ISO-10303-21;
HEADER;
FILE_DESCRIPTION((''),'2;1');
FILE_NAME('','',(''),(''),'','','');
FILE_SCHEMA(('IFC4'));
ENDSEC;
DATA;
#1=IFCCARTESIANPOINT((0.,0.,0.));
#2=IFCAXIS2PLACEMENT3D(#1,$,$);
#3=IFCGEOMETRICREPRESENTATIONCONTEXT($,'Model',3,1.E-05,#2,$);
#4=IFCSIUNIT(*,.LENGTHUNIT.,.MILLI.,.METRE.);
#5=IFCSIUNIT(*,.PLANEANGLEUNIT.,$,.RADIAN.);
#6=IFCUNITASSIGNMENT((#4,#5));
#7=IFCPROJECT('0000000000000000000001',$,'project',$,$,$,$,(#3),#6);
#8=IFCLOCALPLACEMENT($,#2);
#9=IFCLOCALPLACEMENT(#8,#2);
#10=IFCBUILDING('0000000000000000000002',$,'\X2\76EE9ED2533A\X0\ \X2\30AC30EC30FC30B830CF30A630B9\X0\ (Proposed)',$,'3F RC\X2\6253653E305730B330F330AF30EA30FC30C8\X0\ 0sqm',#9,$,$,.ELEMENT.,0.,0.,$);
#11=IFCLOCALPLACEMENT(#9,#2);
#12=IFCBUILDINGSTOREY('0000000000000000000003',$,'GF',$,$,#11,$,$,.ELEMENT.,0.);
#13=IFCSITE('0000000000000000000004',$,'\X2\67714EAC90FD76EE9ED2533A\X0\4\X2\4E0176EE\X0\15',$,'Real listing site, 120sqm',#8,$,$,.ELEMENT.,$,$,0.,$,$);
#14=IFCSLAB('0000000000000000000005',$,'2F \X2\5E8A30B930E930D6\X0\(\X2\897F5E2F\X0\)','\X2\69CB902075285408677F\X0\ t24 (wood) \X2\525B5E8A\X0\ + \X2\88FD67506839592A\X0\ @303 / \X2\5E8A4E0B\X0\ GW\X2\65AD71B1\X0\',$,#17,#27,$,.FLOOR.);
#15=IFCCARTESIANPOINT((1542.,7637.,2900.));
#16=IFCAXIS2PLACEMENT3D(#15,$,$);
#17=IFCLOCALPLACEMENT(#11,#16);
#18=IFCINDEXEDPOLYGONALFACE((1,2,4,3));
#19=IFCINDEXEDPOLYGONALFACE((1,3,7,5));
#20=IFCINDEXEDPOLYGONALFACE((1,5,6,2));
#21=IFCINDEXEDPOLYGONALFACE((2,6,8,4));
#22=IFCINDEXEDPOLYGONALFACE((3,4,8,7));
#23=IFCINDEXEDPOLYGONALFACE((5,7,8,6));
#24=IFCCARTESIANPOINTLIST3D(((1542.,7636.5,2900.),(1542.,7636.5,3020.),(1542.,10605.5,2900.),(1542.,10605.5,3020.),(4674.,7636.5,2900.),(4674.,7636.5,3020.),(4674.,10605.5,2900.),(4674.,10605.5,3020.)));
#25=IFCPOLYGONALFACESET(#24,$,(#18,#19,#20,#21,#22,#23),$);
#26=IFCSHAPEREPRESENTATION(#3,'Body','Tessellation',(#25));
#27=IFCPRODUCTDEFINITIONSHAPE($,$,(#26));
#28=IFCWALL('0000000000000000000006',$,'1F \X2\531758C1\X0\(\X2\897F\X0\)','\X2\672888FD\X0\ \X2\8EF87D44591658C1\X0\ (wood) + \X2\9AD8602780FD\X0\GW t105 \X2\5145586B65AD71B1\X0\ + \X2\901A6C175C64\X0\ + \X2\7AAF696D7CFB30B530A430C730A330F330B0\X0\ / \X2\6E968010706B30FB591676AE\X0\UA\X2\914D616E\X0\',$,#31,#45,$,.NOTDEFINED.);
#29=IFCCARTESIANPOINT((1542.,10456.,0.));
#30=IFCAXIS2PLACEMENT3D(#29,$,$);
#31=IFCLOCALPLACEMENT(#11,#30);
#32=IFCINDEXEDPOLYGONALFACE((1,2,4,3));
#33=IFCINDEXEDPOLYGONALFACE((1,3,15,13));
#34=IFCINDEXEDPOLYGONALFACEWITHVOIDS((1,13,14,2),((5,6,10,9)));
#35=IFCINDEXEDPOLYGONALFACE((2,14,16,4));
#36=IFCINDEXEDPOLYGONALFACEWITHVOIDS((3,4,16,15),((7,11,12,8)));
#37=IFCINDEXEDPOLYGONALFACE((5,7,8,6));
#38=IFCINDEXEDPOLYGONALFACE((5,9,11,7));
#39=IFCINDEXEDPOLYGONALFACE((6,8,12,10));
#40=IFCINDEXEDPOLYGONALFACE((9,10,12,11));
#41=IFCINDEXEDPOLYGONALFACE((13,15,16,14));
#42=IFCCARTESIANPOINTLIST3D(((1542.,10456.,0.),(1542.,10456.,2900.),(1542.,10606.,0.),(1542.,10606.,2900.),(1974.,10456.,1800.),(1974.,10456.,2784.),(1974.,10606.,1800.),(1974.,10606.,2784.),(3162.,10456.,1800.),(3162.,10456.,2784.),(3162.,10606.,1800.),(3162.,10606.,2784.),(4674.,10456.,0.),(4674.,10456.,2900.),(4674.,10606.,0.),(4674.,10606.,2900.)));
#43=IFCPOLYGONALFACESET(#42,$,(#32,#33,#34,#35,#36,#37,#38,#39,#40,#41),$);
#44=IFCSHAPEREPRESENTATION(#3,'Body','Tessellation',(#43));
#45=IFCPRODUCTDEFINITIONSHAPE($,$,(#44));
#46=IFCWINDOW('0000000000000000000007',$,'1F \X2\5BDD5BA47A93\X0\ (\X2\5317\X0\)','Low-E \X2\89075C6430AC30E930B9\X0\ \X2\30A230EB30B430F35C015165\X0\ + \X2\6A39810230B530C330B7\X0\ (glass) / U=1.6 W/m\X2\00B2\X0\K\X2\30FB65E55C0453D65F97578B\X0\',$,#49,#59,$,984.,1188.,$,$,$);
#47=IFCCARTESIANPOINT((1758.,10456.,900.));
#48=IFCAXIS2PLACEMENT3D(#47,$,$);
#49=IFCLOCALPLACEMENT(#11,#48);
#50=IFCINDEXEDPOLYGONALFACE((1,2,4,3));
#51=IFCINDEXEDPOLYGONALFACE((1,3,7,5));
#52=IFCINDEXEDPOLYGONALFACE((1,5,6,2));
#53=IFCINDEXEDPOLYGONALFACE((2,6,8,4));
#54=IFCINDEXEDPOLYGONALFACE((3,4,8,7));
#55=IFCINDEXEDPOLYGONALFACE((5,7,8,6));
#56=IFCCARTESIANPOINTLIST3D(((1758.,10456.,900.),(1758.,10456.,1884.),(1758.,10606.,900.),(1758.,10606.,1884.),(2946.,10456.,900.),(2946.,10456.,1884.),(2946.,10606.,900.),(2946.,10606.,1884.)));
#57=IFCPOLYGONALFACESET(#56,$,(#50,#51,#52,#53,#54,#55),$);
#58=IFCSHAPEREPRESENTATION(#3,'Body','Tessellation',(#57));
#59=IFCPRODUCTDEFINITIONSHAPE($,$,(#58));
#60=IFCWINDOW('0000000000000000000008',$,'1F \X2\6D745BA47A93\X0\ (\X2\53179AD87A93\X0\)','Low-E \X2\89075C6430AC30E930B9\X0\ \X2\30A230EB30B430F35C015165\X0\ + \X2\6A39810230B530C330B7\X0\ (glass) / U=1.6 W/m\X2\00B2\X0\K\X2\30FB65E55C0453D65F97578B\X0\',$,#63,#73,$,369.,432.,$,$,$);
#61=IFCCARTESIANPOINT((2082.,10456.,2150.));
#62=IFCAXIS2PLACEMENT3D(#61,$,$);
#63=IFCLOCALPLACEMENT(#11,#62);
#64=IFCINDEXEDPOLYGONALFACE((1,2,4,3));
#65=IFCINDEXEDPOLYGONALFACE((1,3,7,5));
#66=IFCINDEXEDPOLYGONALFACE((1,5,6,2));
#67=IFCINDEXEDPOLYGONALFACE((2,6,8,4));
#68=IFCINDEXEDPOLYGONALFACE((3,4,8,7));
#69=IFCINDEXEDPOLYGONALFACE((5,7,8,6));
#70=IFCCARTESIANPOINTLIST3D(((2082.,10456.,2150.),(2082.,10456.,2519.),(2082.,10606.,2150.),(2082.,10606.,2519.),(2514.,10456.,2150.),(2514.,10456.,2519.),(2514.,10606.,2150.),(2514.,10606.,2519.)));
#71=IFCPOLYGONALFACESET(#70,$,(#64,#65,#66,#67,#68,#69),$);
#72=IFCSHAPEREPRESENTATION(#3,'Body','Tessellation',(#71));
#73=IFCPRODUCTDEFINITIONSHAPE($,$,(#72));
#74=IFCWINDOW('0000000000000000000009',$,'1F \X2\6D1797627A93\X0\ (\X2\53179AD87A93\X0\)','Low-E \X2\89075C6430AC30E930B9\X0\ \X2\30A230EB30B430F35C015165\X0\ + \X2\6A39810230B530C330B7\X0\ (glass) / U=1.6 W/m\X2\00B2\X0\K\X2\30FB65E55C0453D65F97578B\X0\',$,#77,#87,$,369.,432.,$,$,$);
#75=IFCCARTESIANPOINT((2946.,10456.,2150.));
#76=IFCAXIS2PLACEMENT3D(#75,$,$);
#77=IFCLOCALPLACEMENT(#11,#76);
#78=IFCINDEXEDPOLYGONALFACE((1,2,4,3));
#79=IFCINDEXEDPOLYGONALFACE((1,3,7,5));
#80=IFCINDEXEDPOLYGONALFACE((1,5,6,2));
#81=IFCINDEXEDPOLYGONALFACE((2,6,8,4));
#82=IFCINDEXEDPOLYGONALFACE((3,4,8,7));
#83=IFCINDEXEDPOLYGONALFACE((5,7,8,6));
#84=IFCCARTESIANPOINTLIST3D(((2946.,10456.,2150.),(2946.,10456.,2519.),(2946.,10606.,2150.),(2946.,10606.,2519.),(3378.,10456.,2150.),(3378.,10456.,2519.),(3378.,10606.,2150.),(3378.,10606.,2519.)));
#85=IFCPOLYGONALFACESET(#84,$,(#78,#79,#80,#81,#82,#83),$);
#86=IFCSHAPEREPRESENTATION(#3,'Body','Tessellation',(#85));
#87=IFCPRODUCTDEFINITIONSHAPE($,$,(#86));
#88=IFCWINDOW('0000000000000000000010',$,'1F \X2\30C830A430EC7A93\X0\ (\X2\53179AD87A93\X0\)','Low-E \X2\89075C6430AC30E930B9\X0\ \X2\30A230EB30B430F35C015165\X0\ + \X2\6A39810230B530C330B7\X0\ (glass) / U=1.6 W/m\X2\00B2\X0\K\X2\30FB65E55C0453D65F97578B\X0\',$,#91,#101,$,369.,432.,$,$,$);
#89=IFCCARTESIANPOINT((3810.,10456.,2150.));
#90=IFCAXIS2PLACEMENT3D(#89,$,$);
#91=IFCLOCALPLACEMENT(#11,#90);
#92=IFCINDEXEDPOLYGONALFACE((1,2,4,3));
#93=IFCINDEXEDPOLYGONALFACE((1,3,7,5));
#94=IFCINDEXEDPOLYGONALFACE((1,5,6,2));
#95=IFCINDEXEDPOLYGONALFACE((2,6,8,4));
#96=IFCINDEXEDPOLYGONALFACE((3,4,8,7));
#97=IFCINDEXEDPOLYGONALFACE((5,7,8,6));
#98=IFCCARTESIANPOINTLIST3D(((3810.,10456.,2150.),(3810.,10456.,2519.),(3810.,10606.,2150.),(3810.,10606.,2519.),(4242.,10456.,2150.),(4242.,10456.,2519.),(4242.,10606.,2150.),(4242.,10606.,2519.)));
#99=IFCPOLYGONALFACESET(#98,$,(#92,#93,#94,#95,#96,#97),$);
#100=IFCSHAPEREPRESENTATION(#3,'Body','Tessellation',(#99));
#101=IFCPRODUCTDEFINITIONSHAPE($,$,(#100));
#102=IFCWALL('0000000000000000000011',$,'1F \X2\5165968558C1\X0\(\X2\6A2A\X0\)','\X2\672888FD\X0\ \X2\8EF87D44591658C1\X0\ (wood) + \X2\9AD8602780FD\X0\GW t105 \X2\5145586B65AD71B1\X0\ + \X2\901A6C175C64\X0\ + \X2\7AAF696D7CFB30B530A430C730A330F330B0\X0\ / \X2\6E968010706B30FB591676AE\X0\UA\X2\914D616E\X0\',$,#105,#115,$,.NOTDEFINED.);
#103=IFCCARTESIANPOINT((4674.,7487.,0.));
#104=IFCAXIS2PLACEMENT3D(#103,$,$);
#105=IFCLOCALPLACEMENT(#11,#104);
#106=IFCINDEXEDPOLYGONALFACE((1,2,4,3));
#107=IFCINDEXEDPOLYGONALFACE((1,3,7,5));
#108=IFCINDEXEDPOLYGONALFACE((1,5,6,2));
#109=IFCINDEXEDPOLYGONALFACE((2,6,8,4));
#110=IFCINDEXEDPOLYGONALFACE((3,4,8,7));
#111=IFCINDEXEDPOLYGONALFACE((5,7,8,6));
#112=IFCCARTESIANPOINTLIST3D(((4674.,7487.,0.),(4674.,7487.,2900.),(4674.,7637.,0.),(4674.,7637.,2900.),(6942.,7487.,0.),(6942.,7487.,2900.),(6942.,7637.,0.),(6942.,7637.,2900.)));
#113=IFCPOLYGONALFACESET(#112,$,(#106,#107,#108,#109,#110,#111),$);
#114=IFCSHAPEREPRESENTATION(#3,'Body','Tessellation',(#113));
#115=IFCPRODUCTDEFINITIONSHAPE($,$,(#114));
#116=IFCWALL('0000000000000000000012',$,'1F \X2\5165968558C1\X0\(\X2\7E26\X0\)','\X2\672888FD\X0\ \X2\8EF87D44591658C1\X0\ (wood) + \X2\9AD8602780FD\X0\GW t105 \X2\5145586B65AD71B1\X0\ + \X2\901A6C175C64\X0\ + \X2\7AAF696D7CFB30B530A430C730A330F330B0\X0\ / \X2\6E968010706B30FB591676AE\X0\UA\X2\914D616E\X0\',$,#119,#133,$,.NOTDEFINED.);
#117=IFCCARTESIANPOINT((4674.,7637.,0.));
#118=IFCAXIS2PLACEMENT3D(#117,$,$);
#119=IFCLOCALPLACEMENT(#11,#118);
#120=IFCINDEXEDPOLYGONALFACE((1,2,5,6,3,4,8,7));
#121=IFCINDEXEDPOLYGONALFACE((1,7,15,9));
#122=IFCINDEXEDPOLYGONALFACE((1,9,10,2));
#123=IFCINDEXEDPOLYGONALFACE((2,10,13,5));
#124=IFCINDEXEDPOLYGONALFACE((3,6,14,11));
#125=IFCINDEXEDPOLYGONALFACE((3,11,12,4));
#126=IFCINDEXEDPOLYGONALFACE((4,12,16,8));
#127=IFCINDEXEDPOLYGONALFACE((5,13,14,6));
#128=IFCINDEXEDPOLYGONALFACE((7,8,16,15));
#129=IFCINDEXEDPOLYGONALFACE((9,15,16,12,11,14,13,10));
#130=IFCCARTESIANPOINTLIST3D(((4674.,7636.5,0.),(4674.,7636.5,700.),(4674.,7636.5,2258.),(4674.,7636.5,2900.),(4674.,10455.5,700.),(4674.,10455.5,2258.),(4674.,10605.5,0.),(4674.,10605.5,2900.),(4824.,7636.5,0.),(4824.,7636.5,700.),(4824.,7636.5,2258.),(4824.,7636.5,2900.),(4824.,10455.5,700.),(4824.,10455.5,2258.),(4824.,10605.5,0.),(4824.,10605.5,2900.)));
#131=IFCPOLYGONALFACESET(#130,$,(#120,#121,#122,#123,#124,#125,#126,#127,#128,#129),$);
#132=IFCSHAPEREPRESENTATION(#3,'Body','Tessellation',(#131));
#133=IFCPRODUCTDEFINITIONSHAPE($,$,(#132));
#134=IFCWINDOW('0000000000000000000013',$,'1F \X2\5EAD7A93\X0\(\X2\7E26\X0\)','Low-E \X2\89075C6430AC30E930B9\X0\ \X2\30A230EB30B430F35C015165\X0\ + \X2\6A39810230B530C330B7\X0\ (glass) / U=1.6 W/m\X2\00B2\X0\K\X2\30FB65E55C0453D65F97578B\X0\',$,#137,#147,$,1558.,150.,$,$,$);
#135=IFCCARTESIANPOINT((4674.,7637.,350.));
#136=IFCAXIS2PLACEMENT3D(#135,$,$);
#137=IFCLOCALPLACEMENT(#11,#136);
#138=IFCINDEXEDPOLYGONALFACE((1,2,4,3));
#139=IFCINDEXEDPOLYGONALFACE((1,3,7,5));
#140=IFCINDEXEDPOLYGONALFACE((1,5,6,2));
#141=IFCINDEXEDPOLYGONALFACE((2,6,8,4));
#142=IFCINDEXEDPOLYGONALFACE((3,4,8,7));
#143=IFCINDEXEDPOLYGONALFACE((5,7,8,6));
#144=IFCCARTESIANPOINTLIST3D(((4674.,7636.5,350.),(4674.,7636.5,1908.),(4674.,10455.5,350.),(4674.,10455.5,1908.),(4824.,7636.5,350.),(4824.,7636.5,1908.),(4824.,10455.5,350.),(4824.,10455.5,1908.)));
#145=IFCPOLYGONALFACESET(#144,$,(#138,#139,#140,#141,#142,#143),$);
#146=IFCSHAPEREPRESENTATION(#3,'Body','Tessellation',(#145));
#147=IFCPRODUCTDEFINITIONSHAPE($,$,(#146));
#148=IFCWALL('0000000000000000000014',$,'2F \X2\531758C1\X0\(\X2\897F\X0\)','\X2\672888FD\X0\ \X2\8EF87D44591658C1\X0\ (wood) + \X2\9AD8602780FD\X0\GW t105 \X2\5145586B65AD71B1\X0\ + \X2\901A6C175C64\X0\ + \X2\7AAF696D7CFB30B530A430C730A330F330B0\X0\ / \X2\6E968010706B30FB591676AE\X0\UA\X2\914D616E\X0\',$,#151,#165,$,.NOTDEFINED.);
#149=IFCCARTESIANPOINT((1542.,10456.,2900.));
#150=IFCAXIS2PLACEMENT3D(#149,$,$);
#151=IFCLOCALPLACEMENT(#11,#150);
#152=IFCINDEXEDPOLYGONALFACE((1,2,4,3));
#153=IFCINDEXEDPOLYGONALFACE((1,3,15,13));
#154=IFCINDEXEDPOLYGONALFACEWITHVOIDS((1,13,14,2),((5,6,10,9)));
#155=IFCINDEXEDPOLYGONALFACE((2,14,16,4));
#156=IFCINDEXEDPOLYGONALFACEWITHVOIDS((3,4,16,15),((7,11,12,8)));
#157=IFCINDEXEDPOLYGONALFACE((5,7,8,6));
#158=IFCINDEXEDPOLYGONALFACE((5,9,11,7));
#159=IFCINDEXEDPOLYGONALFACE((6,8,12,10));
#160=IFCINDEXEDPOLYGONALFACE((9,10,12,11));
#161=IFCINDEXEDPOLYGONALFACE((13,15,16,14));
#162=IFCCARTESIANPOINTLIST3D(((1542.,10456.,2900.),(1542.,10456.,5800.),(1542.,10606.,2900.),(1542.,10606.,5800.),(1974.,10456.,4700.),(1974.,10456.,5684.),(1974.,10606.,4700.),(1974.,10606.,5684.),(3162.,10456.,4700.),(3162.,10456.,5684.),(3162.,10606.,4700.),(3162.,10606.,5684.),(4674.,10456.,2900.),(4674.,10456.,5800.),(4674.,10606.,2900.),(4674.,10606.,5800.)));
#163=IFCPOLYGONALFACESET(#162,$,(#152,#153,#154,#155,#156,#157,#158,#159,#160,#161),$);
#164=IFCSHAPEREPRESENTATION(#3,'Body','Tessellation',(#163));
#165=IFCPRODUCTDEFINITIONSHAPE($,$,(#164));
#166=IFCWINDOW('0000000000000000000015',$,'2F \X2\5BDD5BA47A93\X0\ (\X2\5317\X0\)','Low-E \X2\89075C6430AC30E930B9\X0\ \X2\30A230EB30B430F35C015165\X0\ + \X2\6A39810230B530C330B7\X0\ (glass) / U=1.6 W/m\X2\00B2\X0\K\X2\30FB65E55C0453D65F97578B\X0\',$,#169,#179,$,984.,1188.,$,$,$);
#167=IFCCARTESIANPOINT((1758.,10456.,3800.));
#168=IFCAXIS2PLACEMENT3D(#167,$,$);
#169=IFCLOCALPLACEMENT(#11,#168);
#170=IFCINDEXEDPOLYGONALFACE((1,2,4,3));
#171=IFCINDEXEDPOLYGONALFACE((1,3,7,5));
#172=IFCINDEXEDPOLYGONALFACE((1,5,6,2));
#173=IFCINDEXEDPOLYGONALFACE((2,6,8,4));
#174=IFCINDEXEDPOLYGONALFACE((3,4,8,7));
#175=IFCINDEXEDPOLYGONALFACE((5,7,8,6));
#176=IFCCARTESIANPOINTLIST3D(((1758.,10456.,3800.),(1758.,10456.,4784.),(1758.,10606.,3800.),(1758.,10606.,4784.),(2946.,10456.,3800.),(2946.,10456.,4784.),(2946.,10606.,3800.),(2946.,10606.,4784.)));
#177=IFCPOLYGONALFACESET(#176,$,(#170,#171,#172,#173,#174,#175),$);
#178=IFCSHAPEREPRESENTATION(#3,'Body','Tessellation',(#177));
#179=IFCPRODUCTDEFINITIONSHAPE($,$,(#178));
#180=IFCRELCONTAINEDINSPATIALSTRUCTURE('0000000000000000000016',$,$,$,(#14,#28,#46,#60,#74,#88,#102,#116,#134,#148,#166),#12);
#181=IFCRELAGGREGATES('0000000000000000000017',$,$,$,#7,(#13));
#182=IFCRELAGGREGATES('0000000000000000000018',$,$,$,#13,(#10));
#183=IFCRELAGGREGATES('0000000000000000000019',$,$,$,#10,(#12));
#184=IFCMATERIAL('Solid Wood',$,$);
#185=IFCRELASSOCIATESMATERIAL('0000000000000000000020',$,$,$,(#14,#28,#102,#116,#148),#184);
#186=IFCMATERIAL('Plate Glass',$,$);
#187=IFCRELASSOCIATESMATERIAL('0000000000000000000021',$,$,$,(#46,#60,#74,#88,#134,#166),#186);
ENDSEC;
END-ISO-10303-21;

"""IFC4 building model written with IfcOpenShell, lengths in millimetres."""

from ifc_helpers import new_model, si_unit, frame, frame_2d, origin, place, context, project, spatial, rectangle, extrude, material, element, fill, save


model = new_model("IFC4")

# Units and contexts
model_context = context("Model", 3, precision=1e-05, world=origin())
ifc_project = project(units=[si_unit("LENGTHUNIT", "METRE", prefix="MILLI"), si_unit("PLANEANGLEUNIT", "RADIAN")], contexts=[model_context])

# Site, building, storey
site_placement = place(None, origin())
site = spatial("IfcSite", under=ifc_project, at=site_placement, Name="東京都目黒区4丁目15", ObjectType="Real listing site, 120sqm", CompositionType="ELEMENT", RefElevation=0.0)
building_placement = place(site_placement, origin())
building = spatial("IfcBuilding", under=site, at=building_placement, Name="目黒区 ガレージハウス (Proposed)", ObjectType="3F RC打放しコンクリート 0sqm", CompositionType="ELEMENT", ElevationOfRefHeight=0.0, ElevationOfTerrain=0.0)
storey_placement = place(building_placement, origin())
storey = spatial("IfcBuildingStorey", under=building, at=storey_placement, Name="GF", CompositionType="ELEMENT", Elevation=0.0)

# Slab
ifc_material_1 = material(Name="Solid Wood")
slab_1_placement = place(storey_placement, frame((1542.0, 7637.0, 2900.0)))
element("IfcSlab", 1, at=slab_1_placement, inside=storey, material=ifc_material_1, Name="2F 床スラブ(西帯)", Description="構造用合板 t24 (wood) 剛床 + 製材根太 @303 / 床下 GW断熱", PredefinedType="FLOOR", context=model_context, shape_type="SweptSolid", body=[
    extrude(rectangle(XDim=3132.0, YDim=2969.0, at=frame_2d((1566.0, 1484.0))), frame((1542.0, 7637.0, 2900.0)), (0.0, 0.0, 1.0), 120.0),
])

# Wall, openings, windows
wall_1_placement = place(storey_placement, frame((1542.0, 10456.0, 0.0)))
wall_1 = element("IfcWall", 2, at=wall_1_placement, inside=storey, material=ifc_material_1, Name="1F 北壁(西)", Description="木製 軸組外壁 (wood) + 高性能GW t105 充填断熱 + 通気層 + 窯業系サイディング / 準耐火・外皮UA配慮", PredefinedType="NOTDEFINED", context=model_context, shape_type="SweptSolid", body=[
    extrude(rectangle(XDim=3132.0, YDim=150.0, at=frame_2d((1566.0, 75.0))), frame((1542.0, 10456.0, 0.0)), (0.0, 0.0, 1.0), 2900.0),
])
opening_1_placement = place(storey_placement, frame((1758.0, 10456.0, 900.0)))
opening_1 = element("IfcOpeningElement", 3, at=opening_1_placement, cuts=wall_1, PredefinedType="NOTDEFINED", context=model_context, shape_type="SweptSolid", body=[
    extrude(rectangle(XDim=1188.0, YDim=150.0, at=frame_2d((594.0, 75.0))), frame((1758.0, 10456.0, 900.0)), (0.0, 0.0, 1.0), 984.0),
])
opening_2_placement = place(storey_placement, frame((2082.0, 10456.0, 2150.0)))
opening_2 = element("IfcOpeningElement", 4, at=opening_2_placement, cuts=wall_1, PredefinedType="NOTDEFINED", context=model_context, shape_type="SweptSolid", body=[
    extrude(rectangle(XDim=432.0, YDim=150.0, at=frame_2d((216.0, 75.0))), frame((2082.0, 10456.0, 2150.0)), (0.0, 0.0, 1.0), 369.0),
])
opening_3_placement = place(storey_placement, frame((2946.0, 10456.0, 2150.0)))
opening_3 = element("IfcOpeningElement", 5, at=opening_3_placement, cuts=wall_1, PredefinedType="NOTDEFINED", context=model_context, shape_type="SweptSolid", body=[
    extrude(rectangle(XDim=432.0, YDim=150.0, at=frame_2d((216.0, 75.0))), frame((2946.0, 10456.0, 2150.0)), (0.0, 0.0, 1.0), 369.0),
])
opening_4_placement = place(storey_placement, frame((3810.0, 10456.0, 2150.0)))
opening_4 = element("IfcOpeningElement", 6, at=opening_4_placement, cuts=wall_1, PredefinedType="NOTDEFINED", context=model_context, shape_type="SweptSolid", body=[
    extrude(rectangle(XDim=432.0, YDim=150.0, at=frame_2d((216.0, 75.0))), frame((3810.0, 10456.0, 2150.0)), (0.0, 0.0, 1.0), 369.0),
])
ifc_material_2 = material(Name="Plate Glass")
window_1_placement = place(storey_placement, frame((1758.0, 10456.0, 900.0)))
window_1 = element("IfcWindow", 7, at=window_1_placement, inside=storey, material=ifc_material_2, Name="1F 寝室窓 (北)", Description="Low-E 複層ガラス アルゴン封入 + 樹脂サッシ (glass) / U=1.6 W/m²K・日射取得型", OverallHeight=984.0, OverallWidth=1188.0, context=model_context, shape_type="SweptSolid", body=[
    extrude(rectangle(XDim=1188.0, YDim=150.0, at=frame_2d((594.0, 75.0))), frame((1758.0, 10456.0, 900.0)), (0.0, 0.0, 1.0), 984.0),
])
fill(opening_1, window_1)
window_2_placement = place(storey_placement, frame((2082.0, 10456.0, 2150.0)))
window_2 = element("IfcWindow", 8, at=window_2_placement, inside=storey, material=ifc_material_2, Name="1F 浴室窓 (北高窓)", Description="Low-E 複層ガラス アルゴン封入 + 樹脂サッシ (glass) / U=1.6 W/m²K・日射取得型", OverallHeight=369.0, OverallWidth=432.0, context=model_context, shape_type="SweptSolid", body=[
    extrude(rectangle(XDim=432.0, YDim=150.0, at=frame_2d((216.0, 75.0))), frame((2082.0, 10456.0, 2150.0)), (0.0, 0.0, 1.0), 369.0),
])
fill(opening_2, window_2)
window_3_placement = place(storey_placement, frame((2946.0, 10456.0, 2150.0)))
window_3 = element("IfcWindow", 9, at=window_3_placement, inside=storey, material=ifc_material_2, Name="1F 洗面窓 (北高窓)", Description="Low-E 複層ガラス アルゴン封入 + 樹脂サッシ (glass) / U=1.6 W/m²K・日射取得型", OverallHeight=369.0, OverallWidth=432.0, context=model_context, shape_type="SweptSolid", body=[
    extrude(rectangle(XDim=432.0, YDim=150.0, at=frame_2d((216.0, 75.0))), frame((2946.0, 10456.0, 2150.0)), (0.0, 0.0, 1.0), 369.0),
])
fill(opening_3, window_3)
window_4_placement = place(storey_placement, frame((3810.0, 10456.0, 2150.0)))
window_4 = element("IfcWindow", 10, at=window_4_placement, inside=storey, material=ifc_material_2, Name="1F トイレ窓 (北高窓)", Description="Low-E 複層ガラス アルゴン封入 + 樹脂サッシ (glass) / U=1.6 W/m²K・日射取得型", OverallHeight=369.0, OverallWidth=432.0, context=model_context, shape_type="SweptSolid", body=[
    extrude(rectangle(XDim=432.0, YDim=150.0, at=frame_2d((216.0, 75.0))), frame((3810.0, 10456.0, 2150.0)), (0.0, 0.0, 1.0), 369.0),
])
fill(opening_4, window_4)

# Wall
wall_2_placement = place(storey_placement, frame((4674.0, 7487.0, 0.0)))
element("IfcWall", 11, at=wall_2_placement, inside=storey, material=ifc_material_1, Name="1F 入隅壁(横)", Description="木製 軸組外壁 (wood) + 高性能GW t105 充填断熱 + 通気層 + 窯業系サイディング / 準耐火・外皮UA配慮", PredefinedType="NOTDEFINED", context=model_context, shape_type="SweptSolid", body=[
    extrude(rectangle(XDim=2268.0, YDim=150.0, at=frame_2d((1134.0, 75.0))), frame((4674.0, 7487.0, 0.0)), (0.0, 0.0, 1.0), 2900.0),
])

# Wall, opening, window
wall_3_placement = place(storey_placement, frame((4674.0, 7637.0, 0.0)))
wall_3 = element("IfcWall", 12, at=wall_3_placement, inside=storey, material=ifc_material_1, Name="1F 入隅壁(縦)", Description="木製 軸組外壁 (wood) + 高性能GW t105 充填断熱 + 通気層 + 窯業系サイディング / 準耐火・外皮UA配慮", PredefinedType="NOTDEFINED", context=model_context, shape_type="SweptSolid", body=[
    extrude(rectangle(XDim=150.0, YDim=2969.0, at=frame_2d((75.0, 1484.0))), frame((4674.0, 7637.0, 0.0)), (0.0, 0.0, 1.0), 2900.0),
])
opening_5_placement = place(storey_placement, frame((4674.0, 7637.0, 350.0)))
opening_5 = element("IfcOpeningElement", 13, at=opening_5_placement, cuts=wall_3, PredefinedType="NOTDEFINED", context=model_context, shape_type="SweptSolid", body=[
    extrude(rectangle(XDim=150.0, YDim=2819.0, at=frame_2d((75.0, 1409.0))), frame((4674.0, 7637.0, 350.0)), (0.0, 0.0, 1.0), 1558.0),
])
window_5_placement = place(storey_placement, frame((4674.0, 7637.0, 350.0)))
window_5 = element("IfcWindow", 14, at=window_5_placement, inside=storey, material=ifc_material_2, Name="1F 庭窓(縦)", Description="Low-E 複層ガラス アルゴン封入 + 樹脂サッシ (glass) / U=1.6 W/m²K・日射取得型", OverallHeight=1558.0, OverallWidth=150.0, context=model_context, shape_type="SweptSolid", body=[
    extrude(rectangle(XDim=150.0, YDim=2819.0, at=frame_2d((75.0, 1409.0))), frame((4674.0, 7637.0, 350.0)), (0.0, 0.0, 1.0), 1558.0),
])
fill(opening_5, window_5)

# Wall, opening, window
wall_4_placement = place(storey_placement, frame((1542.0, 10456.0, 2900.0)))
wall_4 = element("IfcWall", 15, at=wall_4_placement, inside=storey, material=ifc_material_1, Name="2F 北壁(西)", Description="木製 軸組外壁 (wood) + 高性能GW t105 充填断熱 + 通気層 + 窯業系サイディング / 準耐火・外皮UA配慮", PredefinedType="NOTDEFINED", context=model_context, shape_type="SweptSolid", body=[
    extrude(rectangle(XDim=3132.0, YDim=150.0, at=frame_2d((1566.0, 75.0))), frame((1542.0, 10456.0, 2900.0)), (0.0, 0.0, 1.0), 2900.0),
])
opening_6_placement = place(storey_placement, frame((1758.0, 10456.0, 3800.0)))
opening_6 = element("IfcOpeningElement", 16, at=opening_6_placement, cuts=wall_4, PredefinedType="NOTDEFINED", context=model_context, shape_type="SweptSolid", body=[
    extrude(rectangle(XDim=1188.0, YDim=150.0, at=frame_2d((594.0, 75.0))), frame((1758.0, 10456.0, 3800.0)), (0.0, 0.0, 1.0), 984.0),
])
window_6_placement = place(storey_placement, frame((1758.0, 10456.0, 3800.0)))
window_6 = element("IfcWindow", 17, at=window_6_placement, inside=storey, material=ifc_material_2, Name="2F 寝室窓 (北)", Description="Low-E 複層ガラス アルゴン封入 + 樹脂サッシ (glass) / U=1.6 W/m²K・日射取得型", OverallHeight=984.0, OverallWidth=1188.0, context=model_context, shape_type="SweptSolid", body=[
    extrude(rectangle(XDim=1188.0, YDim=150.0, at=frame_2d((594.0, 75.0))), frame((1758.0, 10456.0, 3800.0)), (0.0, 0.0, 1.0), 984.0),
])
fill(opening_6, window_6)

save(model, "model.ifc")
